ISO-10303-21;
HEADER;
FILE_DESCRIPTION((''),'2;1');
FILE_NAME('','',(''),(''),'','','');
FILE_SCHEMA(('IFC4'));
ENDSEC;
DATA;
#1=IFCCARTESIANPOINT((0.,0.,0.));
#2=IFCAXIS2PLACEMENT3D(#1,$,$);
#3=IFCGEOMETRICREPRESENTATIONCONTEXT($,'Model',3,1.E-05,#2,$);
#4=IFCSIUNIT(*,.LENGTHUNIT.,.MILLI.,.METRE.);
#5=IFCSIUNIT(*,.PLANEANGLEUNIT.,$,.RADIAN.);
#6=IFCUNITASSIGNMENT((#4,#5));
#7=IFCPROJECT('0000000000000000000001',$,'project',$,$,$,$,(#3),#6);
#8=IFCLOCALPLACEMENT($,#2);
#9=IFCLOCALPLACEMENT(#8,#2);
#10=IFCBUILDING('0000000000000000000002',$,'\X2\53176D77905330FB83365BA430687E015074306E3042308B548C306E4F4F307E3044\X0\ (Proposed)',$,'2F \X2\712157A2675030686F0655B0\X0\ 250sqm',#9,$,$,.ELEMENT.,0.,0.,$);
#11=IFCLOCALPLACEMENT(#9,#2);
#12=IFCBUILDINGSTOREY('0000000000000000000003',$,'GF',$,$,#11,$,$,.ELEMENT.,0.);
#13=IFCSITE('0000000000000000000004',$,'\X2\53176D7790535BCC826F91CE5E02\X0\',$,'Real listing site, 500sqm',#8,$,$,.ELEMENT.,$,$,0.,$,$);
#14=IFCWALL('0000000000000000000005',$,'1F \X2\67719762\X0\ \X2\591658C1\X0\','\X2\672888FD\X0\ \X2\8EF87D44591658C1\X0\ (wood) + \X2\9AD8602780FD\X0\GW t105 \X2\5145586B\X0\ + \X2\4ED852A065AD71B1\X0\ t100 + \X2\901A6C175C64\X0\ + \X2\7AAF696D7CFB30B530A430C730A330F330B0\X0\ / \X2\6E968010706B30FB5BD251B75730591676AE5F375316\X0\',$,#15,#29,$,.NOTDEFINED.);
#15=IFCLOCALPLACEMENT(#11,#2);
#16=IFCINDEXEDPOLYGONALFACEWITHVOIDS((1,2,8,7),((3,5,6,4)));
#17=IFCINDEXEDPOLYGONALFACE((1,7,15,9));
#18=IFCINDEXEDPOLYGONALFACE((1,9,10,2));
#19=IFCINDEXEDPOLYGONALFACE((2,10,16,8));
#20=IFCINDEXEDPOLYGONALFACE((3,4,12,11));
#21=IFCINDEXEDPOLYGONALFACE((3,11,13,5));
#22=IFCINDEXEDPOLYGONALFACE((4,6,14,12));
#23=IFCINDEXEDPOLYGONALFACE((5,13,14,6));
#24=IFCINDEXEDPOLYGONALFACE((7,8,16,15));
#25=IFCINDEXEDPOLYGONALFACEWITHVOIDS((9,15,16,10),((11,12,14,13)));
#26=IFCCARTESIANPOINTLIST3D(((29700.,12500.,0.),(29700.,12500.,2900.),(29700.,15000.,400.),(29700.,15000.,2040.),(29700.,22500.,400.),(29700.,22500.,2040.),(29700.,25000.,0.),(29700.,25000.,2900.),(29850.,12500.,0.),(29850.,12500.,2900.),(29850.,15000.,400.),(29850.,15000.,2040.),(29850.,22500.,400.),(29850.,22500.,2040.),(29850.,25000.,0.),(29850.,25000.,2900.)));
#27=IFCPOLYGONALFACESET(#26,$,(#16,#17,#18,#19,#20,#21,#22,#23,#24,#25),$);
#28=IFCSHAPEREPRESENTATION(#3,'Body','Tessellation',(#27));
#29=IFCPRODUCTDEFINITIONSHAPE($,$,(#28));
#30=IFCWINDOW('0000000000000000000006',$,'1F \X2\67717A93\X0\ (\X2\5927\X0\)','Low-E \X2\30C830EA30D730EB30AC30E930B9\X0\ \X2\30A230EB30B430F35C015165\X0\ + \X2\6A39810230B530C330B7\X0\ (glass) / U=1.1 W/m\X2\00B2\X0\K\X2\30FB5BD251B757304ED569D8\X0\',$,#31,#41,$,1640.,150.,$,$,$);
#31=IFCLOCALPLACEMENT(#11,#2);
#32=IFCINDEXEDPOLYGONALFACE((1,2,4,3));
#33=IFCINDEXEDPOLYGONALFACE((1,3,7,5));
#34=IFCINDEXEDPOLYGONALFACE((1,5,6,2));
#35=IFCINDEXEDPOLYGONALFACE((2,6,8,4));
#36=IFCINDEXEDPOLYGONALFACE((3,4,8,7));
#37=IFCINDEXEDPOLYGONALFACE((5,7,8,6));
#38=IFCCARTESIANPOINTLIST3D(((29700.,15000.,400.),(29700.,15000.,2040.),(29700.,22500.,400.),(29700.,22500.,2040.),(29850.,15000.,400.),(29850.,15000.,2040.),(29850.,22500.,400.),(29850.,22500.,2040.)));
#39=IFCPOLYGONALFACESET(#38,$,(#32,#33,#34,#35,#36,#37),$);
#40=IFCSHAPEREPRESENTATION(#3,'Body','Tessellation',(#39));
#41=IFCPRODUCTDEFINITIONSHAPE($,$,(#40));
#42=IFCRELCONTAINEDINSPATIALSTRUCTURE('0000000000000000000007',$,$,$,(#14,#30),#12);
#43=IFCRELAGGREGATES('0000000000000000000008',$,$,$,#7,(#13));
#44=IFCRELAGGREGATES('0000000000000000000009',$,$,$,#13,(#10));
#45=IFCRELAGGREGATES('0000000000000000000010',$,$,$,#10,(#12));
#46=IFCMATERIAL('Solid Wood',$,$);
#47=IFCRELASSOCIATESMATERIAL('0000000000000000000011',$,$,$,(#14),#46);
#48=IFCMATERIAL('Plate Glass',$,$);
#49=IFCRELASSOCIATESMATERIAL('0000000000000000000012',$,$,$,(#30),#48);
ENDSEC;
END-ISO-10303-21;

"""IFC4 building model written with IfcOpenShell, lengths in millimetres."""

from ifc_helpers import new_model, si_unit, frame, frame_2d, origin, place, context, project, spatial, rectangle, extrude, material, element, fill, save


model = new_model("IFC4")

# Units and contexts
model_context = context("Model", 3, precision=1e-05, world=origin())
ifc_project = project(units=[si_unit("LENGTHUNIT", "METRE", prefix="MILLI"), si_unit("PLANEANGLEUNIT", "RADIAN")], contexts=[model_context])

# Site, building, storey
site_placement = place(None, origin())
site = spatial("IfcSite", under=ifc_project, at=site_placement, Name="北海道富良野市", ObjectType="Real listing site, 500sqm", CompositionType="ELEMENT", RefElevation=0.0)
building_placement = place(site_placement, origin())
building = spatial("IfcBuilding", under=site, at=building_placement, Name="北海道・茶室と縁側のある和の住まい (Proposed)", ObjectType="2F 無垢材と漆喰 250sqm", CompositionType="ELEMENT", ElevationOfRefHeight=0.0, ElevationOfTerrain=0.0)
storey_placement = place(building_placement, origin())
storey = spatial("IfcBuildingStorey", under=building, at=storey_placement, Name="GF", CompositionType="ELEMENT", Elevation=0.0)

# Shared definitions
ifc_material_1 = material(Name="Solid Wood")

# Wall, opening, window
wall_1_placement = place(storey_placement, frame((14850.0, 6250.0, 0.0)))
wall_1 = element("IfcWall", 1, at=wall_1_placement, inside=storey, material=ifc_material_1, Name="1F 東面 外壁", Description="木製 軸組外壁 (wood) + 高性能GW t105 充填 + 付加断熱 t100 + 通気層 + 窯業系サイディング / 準耐火・寒冷地外皮強化", PredefinedType="NOTDEFINED", context=model_context, shape_type="SweptSolid", body=[
    extrude(rectangle(XDim=150.0, YDim=12500.0, at=frame_2d((75.0, 6250.0))), frame((14850.0, 6250.0, 0.0)), (0.0, 0.0, 1.0), 2900.0),
])
opening_1_placement = place(storey_placement, frame((14850.0, 7500.0, 200.0)))
opening_1 = element("IfcOpeningElement", 2, at=opening_1_placement, cuts=wall_1, PredefinedType="NOTDEFINED", context=model_context, shape_type="SweptSolid", body=[
    extrude(rectangle(XDim=150.0, YDim=7500.0, at=frame_2d((75.0, 3750.0))), frame((14850.0, 7500.0, 200.0)), (0.0, 0.0, 1.0), 1640.0),
])
ifc_material_2 = material(Name="Plate Glass")
window_1_placement = place(storey_placement, frame((14850.0, 7500.0, 200.0)))
window_1 = element("IfcWindow", 3, at=window_1_placement, inside=storey, material=ifc_material_2, Name="1F 東窓 (大)", Description="Low-E トリプルガラス アルゴン封入 + 樹脂サッシ (glass) / U=1.1 W/m²K・寒冷地仕様", OverallHeight=1640.0, OverallWidth=150.0, context=model_context, shape_type="SweptSolid", body=[
    extrude(rectangle(XDim=150.0, YDim=7500.0, at=frame_2d((75.0, 3750.0))), frame((14850.0, 7500.0, 200.0)), (0.0, 0.0, 1.0), 1640.0),
])
fill(opening_1, window_1)

save(model, "model.ifc")
